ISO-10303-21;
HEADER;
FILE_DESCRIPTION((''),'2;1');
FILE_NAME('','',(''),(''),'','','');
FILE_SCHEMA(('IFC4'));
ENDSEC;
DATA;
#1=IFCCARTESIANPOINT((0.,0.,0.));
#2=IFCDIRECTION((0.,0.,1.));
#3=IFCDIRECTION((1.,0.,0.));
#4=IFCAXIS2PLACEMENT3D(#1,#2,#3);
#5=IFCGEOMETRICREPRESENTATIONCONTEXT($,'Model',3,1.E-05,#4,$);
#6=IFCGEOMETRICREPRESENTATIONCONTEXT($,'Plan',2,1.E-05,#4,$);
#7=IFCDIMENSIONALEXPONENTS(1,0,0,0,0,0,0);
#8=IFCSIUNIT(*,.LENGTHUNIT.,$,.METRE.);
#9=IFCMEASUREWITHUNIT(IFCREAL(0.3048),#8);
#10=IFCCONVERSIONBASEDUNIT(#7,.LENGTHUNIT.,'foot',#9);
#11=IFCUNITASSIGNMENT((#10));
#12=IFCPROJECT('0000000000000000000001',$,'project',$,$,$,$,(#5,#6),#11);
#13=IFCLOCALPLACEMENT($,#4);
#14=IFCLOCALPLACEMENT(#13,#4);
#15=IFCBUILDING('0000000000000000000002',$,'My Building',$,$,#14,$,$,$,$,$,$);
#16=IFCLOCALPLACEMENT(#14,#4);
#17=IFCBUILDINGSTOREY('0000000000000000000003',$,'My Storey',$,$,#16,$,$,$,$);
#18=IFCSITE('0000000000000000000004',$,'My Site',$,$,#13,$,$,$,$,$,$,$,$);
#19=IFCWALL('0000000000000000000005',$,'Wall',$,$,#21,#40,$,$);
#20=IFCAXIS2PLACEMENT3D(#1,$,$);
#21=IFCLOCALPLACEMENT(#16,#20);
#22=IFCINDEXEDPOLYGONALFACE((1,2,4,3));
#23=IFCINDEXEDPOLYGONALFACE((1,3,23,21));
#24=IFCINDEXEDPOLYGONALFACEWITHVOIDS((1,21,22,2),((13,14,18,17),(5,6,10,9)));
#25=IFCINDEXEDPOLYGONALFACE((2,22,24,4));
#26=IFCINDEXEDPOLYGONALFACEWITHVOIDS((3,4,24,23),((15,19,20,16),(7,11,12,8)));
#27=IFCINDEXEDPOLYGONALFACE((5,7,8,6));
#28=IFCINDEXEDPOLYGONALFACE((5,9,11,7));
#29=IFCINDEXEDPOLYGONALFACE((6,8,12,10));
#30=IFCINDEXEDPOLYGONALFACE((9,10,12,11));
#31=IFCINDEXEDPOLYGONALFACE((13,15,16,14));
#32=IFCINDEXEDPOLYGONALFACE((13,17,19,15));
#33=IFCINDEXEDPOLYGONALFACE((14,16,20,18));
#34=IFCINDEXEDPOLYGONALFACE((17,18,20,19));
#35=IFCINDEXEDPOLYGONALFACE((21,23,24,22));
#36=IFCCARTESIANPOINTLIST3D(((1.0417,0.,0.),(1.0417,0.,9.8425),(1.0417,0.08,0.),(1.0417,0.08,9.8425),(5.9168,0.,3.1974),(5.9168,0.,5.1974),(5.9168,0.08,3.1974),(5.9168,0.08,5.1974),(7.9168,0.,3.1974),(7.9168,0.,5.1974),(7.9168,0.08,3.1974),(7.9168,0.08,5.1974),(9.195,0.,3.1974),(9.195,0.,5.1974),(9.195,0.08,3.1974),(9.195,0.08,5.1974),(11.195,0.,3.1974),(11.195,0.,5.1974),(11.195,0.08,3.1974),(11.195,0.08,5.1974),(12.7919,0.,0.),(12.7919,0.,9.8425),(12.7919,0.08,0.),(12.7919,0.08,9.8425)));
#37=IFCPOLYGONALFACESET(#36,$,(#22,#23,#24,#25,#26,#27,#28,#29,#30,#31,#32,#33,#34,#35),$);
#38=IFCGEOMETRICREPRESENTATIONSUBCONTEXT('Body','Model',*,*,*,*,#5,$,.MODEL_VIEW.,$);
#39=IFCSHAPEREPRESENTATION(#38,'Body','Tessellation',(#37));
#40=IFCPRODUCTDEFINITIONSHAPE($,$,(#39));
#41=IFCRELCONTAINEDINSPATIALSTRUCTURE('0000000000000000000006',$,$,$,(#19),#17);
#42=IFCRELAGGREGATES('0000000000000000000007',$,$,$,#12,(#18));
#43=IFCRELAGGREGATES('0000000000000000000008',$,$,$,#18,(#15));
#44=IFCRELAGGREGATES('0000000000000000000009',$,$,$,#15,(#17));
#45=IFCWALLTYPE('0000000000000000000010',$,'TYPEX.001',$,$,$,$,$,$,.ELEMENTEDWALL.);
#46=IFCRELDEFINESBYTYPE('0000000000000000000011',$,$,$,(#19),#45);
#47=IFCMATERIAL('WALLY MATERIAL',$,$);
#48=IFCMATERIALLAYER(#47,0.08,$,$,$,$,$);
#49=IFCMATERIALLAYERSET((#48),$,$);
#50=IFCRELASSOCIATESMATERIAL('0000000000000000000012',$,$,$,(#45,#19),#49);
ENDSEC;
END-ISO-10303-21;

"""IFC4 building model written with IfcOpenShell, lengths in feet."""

from ifc_helpers import new_model, entity, si_unit, converted_unit, frame, origin_with_axes, place, context, subcontext, project, spatial, polyline, outline, extrude, material, layer, layer_set, layer_usage, type_object, element, save


model = new_model("IFC4")

# Units and contexts
model_context = context("Model", 3, precision=1e-05, world=origin_with_axes())
plan_context = context("Plan", 2, precision=1e-05, world=origin_with_axes())
body_context = subcontext(model_context, "Body", "Model", "MODEL_VIEW")
ifc_project = project(units=[converted_unit("LENGTHUNIT", "foot", entity("IfcReal", 0.3048), si_unit("LENGTHUNIT", "METRE"), dimensions=[1, 0, 0, 0, 0, 0, 0])], contexts=[model_context, plan_context])

# Site, building, storey
site_placement = place(None, origin_with_axes())
site = spatial("IfcSite", under=ifc_project, at=site_placement, Name="My Site")
building_placement = place(site_placement, origin_with_axes())
building = spatial("IfcBuilding", under=site, at=building_placement, Name="My Building")
storey_placement = place(building_placement, origin_with_axes())
storey = spatial("IfcBuildingStorey", under=building, at=storey_placement, Name="My Storey")

# Wall, openings
ifc_material = material(Name="WALLY MATERIAL")
ifc_layer = layer(ifc_material, 0.08)
ifc_layer_set = layer_set([ifc_layer])
ifc_layer_usage = layer_usage(ifc_layer_set, "AXIS2", "POSITIVE", 0.0)
wall_type = type_object("IfcWallType", Name="TYPEX.001", PredefinedType="ELEMENTEDWALL", material=ifc_layer_set)
wall_placement = place(storey_placement, frame((3.2808, 0.08, 0.0), z_axis=(0.0, 0.0, 1.0), x_axis=(-1.0, 0.0, 0.0)))
wall = element("IfcWall", 1, at=wall_placement, inside=storey, type_object=wall_type, material=ifc_layer_usage, Name="Wall", context=body_context, shape_type="SweptSolid", body=[
    extrude(outline(polyline([(-0.04, -5.8751), (0.04, -5.8751), (0.04, 5.8751), (-0.04, 5.8751), (-0.04, -5.8751)])), frame((-3.6359, 0.04, 0.0), z_axis=(0.0, 0.0, -1.0), x_axis=(0.0, -1.0, 0.0)), (0.0, 0.0, -1.0), 9.8425),
])
opening_1_placement = place(wall_placement, frame((-4.6359, 0.0817, 5.1974), z_axis=(0.0, 0.0, 1.0), x_axis=(-1.0, 0.0, 0.0)))
element("IfcOpeningElement", 2, at=opening_1_placement, cuts=wall, context=body_context, shape_type="SweptSolid", body=[
    extrude(outline(polyline([(-1.0, -1.0), (1.0, -1.0), (1.0, 1.0), (-1.0, 1.0), (-1.0, -1.0)])), frame((-1.0, 0.0, -2.0), z_axis=(0.0, 0.0, -1.0), x_axis=(1.0, 0.0, 0.0)), (0.0, 0.0, -1.0), 2.0),
])
opening_2_placement = place(wall_placement, frame((-7.9142, 0.0817, 5.1974), z_axis=(0.0, 0.0, 1.0), x_axis=(-1.0, 0.0, 0.0)))
element("IfcOpeningElement", 3, at=opening_2_placement, cuts=wall, context=body_context, shape_type="SweptSolid", body=[
    extrude(outline(polyline([(-1.0, -1.0), (1.0, -1.0), (1.0, 1.0), (-1.0, 1.0), (-1.0, -1.0)])), frame((-1.0, 0.0, -2.0), z_axis=(0.0, 0.0, -1.0), x_axis=(1.0, 0.0, 0.0)), (0.0, 0.0, -1.0), 2.0),
])

save(model, "model.ifc")
